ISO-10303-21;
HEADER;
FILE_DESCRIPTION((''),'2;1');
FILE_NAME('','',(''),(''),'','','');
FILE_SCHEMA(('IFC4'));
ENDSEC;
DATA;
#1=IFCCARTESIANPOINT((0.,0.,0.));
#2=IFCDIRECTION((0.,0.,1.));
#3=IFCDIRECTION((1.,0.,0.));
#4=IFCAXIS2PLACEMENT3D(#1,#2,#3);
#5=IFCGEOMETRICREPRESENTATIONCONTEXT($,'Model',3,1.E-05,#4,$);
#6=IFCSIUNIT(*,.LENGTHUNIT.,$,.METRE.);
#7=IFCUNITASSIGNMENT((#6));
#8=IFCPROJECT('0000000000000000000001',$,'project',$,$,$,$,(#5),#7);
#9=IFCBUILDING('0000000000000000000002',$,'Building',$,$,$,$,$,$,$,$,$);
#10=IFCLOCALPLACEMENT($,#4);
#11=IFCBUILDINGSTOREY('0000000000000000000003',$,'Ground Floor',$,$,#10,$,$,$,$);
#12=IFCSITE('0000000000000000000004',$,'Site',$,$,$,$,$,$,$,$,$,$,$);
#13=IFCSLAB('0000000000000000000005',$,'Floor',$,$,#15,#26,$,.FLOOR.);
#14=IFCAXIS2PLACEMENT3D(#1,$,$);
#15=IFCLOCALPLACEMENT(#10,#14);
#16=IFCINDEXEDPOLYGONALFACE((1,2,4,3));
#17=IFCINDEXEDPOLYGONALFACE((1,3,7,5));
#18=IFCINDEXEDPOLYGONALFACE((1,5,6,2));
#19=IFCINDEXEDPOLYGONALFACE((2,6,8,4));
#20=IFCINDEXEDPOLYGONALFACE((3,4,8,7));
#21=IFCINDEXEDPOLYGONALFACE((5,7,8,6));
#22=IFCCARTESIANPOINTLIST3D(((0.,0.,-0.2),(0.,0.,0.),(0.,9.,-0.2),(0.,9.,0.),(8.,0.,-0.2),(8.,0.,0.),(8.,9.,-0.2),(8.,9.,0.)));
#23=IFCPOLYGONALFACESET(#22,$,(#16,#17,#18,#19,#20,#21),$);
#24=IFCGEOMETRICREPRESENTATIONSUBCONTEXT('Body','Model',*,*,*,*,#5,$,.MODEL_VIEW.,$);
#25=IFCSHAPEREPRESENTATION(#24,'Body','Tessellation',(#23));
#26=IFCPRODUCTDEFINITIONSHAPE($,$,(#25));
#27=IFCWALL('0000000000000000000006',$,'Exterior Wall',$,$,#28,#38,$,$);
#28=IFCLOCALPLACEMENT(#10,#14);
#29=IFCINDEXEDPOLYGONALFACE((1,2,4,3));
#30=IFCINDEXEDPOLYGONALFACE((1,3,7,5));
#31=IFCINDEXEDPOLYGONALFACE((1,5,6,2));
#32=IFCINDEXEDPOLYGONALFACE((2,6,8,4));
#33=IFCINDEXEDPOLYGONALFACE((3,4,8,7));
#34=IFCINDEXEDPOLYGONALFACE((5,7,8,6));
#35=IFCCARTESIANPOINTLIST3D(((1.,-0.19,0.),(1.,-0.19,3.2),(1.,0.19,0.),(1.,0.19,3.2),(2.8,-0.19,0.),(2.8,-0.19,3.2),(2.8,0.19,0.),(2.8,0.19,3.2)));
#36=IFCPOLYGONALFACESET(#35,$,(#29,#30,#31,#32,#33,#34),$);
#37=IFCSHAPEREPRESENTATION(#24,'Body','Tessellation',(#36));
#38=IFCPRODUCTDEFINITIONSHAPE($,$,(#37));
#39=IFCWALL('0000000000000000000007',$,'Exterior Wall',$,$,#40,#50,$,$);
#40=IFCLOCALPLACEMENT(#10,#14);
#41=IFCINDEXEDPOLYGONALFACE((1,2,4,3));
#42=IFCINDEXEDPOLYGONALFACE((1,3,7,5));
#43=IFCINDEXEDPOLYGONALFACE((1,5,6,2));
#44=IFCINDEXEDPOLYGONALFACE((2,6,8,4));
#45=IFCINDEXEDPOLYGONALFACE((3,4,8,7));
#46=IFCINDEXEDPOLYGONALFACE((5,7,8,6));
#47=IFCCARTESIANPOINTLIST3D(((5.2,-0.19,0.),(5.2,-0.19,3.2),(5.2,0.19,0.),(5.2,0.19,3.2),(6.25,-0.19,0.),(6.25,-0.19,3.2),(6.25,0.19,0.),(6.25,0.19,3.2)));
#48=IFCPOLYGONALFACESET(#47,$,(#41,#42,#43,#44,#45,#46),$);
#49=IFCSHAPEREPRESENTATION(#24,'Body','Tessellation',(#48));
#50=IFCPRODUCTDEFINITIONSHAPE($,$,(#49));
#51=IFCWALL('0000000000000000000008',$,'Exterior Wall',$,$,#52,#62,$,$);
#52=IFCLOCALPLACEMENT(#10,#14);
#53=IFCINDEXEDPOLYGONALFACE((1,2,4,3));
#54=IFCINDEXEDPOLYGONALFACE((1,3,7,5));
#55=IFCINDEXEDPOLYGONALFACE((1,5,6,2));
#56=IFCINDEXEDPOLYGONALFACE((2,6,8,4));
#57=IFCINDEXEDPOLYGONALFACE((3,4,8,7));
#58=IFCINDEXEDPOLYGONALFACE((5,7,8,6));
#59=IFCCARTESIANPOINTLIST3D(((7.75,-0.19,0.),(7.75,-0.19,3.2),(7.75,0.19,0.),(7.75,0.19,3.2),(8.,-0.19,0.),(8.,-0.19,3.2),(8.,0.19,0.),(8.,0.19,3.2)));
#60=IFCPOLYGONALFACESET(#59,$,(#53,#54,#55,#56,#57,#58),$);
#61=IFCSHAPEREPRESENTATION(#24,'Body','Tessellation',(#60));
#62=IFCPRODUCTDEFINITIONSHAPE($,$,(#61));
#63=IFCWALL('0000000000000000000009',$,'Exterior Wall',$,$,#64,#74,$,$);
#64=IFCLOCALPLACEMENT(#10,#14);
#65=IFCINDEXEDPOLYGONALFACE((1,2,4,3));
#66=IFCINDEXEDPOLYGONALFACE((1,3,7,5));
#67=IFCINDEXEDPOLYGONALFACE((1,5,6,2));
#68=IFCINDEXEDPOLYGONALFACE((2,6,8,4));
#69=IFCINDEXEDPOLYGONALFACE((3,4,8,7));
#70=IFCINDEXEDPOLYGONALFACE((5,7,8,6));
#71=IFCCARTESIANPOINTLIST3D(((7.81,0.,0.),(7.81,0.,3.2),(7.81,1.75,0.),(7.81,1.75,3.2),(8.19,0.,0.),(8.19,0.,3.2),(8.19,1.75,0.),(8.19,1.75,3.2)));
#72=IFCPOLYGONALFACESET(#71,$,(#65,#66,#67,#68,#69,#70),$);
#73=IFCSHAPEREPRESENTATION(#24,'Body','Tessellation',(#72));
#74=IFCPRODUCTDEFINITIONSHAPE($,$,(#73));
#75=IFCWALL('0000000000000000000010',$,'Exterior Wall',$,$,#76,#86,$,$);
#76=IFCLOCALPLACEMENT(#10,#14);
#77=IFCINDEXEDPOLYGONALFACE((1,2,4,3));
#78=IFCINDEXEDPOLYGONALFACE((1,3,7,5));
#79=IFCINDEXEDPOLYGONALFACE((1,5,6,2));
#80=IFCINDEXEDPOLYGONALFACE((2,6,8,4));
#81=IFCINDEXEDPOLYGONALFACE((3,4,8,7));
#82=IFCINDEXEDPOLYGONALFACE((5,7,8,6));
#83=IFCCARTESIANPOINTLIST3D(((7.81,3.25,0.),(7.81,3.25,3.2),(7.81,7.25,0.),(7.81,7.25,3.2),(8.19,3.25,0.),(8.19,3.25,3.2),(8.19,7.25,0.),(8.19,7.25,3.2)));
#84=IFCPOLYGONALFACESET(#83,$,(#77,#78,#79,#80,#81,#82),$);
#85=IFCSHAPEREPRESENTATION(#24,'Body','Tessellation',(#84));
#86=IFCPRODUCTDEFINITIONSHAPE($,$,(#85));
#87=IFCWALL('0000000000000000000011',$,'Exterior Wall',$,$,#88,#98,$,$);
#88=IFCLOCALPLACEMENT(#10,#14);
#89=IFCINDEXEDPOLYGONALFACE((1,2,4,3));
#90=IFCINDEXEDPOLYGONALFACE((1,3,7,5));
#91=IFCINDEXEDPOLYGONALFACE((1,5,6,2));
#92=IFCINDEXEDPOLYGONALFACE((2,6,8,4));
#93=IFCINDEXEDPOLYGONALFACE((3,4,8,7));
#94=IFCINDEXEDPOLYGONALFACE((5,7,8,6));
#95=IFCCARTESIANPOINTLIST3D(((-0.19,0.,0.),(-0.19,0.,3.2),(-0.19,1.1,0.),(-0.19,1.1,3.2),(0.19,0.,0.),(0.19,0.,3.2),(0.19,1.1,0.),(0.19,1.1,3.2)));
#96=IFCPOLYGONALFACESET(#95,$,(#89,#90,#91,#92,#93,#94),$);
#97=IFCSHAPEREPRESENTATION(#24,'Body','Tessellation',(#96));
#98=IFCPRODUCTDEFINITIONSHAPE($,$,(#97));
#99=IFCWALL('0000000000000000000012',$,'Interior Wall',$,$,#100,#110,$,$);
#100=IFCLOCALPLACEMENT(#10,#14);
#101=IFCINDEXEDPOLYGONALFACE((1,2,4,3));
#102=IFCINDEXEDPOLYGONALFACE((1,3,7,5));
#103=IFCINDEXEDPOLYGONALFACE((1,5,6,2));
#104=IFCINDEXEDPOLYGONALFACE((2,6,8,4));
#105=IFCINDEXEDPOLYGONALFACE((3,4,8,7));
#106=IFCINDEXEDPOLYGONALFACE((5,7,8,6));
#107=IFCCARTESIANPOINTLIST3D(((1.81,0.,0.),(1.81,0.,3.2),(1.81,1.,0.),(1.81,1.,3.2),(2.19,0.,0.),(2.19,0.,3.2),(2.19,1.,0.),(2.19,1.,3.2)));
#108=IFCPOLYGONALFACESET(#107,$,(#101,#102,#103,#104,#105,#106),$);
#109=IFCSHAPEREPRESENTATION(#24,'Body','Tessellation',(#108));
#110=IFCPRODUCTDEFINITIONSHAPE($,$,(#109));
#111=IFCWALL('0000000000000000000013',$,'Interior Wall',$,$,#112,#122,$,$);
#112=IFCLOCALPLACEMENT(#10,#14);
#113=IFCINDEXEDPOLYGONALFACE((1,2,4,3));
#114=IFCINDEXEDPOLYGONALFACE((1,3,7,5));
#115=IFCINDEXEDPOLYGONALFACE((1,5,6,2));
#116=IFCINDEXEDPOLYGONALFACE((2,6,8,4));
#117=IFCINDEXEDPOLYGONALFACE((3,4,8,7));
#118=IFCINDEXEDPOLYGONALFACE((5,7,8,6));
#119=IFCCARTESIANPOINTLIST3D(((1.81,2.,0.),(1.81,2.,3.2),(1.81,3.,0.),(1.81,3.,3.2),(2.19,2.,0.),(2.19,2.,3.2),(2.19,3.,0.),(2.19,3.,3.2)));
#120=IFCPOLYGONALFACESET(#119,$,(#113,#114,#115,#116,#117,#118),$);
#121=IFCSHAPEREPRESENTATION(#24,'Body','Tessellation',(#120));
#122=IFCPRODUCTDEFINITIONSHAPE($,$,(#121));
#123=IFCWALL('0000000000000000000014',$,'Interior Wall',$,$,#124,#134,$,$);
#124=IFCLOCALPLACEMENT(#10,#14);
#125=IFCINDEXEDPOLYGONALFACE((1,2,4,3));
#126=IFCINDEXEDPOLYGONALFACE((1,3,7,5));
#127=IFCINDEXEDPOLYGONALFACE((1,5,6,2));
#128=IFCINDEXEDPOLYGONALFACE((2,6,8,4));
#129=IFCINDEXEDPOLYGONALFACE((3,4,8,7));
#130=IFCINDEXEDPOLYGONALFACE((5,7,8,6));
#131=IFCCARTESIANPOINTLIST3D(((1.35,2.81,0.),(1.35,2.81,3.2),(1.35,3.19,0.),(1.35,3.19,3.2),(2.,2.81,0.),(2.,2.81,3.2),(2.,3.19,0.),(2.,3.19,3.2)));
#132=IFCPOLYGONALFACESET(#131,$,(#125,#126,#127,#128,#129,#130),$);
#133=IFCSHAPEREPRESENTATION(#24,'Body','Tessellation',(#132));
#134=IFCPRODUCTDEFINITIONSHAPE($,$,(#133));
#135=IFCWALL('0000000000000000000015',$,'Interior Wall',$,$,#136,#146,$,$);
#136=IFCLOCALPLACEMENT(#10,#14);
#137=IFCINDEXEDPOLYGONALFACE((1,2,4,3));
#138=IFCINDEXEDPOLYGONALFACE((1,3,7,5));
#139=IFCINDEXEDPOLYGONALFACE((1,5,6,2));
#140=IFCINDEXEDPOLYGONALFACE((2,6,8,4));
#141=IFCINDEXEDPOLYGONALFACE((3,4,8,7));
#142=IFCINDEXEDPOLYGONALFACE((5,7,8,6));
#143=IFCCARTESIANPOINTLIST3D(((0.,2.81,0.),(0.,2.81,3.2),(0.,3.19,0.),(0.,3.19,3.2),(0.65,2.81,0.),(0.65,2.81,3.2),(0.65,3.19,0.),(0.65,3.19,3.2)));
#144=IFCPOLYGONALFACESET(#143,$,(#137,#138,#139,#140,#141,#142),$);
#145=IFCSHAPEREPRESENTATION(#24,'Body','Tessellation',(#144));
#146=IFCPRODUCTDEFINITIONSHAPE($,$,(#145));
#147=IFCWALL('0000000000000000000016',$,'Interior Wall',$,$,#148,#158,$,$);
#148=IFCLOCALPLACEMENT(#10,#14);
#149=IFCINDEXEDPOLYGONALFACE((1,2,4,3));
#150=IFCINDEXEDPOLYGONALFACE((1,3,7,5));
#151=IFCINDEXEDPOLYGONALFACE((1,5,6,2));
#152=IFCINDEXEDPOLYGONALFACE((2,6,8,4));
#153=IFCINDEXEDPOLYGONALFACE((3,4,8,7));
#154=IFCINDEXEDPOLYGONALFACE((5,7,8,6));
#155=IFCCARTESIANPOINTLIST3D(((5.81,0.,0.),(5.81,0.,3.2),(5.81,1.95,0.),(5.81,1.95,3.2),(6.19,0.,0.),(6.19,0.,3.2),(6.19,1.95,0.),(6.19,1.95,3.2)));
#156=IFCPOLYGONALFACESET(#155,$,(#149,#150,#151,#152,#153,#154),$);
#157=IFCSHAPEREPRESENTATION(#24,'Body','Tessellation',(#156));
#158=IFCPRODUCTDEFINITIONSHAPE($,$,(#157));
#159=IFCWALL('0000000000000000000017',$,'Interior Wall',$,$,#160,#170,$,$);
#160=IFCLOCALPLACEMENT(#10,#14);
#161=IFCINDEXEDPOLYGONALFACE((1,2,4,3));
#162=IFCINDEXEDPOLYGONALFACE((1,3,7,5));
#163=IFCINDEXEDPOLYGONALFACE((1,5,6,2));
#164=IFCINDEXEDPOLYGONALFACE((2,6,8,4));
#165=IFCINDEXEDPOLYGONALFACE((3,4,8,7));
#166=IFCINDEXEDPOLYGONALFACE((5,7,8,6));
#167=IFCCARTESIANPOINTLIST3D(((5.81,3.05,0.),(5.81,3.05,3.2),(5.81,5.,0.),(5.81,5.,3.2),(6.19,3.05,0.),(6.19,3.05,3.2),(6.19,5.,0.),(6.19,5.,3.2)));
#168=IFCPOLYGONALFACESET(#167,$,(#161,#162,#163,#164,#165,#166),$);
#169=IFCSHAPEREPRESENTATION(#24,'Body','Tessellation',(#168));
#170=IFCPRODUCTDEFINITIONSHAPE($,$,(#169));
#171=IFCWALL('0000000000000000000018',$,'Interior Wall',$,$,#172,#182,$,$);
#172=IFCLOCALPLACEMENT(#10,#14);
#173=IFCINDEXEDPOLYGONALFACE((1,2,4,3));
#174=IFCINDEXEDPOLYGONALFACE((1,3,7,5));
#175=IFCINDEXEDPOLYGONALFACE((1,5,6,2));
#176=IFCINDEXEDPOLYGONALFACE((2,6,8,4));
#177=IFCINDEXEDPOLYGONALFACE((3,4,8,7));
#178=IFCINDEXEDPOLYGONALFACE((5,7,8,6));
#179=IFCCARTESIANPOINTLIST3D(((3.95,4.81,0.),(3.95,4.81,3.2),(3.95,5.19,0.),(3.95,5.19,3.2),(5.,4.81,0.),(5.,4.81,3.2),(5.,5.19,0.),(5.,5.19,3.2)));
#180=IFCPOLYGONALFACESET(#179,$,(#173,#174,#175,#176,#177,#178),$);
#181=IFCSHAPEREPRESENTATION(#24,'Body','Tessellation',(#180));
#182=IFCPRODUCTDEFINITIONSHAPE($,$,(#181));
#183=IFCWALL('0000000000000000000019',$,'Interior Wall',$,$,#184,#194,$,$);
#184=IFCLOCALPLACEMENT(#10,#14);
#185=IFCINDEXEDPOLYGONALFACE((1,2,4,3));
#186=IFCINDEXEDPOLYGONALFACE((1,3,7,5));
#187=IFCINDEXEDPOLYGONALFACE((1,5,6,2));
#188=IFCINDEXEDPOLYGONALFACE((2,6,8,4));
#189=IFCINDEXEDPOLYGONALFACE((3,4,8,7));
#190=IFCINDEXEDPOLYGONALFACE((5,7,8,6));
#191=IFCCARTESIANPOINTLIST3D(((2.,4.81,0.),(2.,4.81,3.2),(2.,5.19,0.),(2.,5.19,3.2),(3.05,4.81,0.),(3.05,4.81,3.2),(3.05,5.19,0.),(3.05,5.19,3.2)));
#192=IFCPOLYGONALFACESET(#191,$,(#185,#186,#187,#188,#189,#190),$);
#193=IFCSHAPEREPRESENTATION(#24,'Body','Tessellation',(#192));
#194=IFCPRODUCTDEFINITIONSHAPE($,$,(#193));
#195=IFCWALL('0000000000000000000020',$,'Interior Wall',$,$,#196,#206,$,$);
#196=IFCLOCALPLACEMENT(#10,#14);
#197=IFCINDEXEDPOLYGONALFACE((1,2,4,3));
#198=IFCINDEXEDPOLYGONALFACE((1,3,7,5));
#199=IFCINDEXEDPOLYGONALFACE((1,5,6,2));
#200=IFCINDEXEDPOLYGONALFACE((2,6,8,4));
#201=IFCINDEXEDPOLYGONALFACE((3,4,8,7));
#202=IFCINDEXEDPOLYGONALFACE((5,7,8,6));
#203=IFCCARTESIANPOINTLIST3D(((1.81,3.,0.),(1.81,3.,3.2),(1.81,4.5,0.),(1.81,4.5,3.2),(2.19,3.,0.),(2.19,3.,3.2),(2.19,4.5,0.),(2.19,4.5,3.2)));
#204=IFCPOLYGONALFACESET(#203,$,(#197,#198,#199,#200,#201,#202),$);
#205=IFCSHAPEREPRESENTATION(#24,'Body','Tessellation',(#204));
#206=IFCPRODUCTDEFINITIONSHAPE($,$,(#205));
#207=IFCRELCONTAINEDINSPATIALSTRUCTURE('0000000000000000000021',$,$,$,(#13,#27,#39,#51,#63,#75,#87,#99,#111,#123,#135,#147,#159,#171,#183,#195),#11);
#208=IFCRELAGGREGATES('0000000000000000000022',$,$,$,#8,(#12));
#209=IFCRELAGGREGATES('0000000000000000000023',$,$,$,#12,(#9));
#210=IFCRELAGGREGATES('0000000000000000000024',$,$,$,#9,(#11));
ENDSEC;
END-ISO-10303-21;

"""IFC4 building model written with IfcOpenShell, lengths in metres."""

from ifc_helpers import new_model, si_unit, frame, origin_with_axes, place, context, subcontext, project, spatial, indexed_curve, outline, extrude, element, save


model = new_model("IFC4")

# Units and contexts
model_context = context("Model", 3, precision=1e-05, world=origin_with_axes())
body_context = subcontext(model_context, "Body", "Model", "MODEL_VIEW")
ifc_project = project(units=[si_unit("LENGTHUNIT", "METRE")], contexts=[model_context])

# Site, building, storey
site = spatial("IfcSite", under=ifc_project, Name="Site")
building = spatial("IfcBuilding", under=site, Name="Building")
storey_placement = place(None, origin_with_axes())
storey = spatial("IfcBuildingStorey", under=building, at=storey_placement, Name="Ground Floor")

# Slab
slab_placement = place(storey_placement, frame((0.0, 0.0, -0.2), z_axis=(0.0, 0.0, 1.0), x_axis=(1.0, 0.0, 0.0)))
element("IfcSlab", 1, at=slab_placement, inside=storey, Name="Floor", PredefinedType="FLOOR", context=body_context, shape_type="SweptSolid", body=[
    extrude(outline(indexed_curve([(0.0, 0.0), (8.0, 0.0), (8.0, 9.0), (0.0, 9.0)])), None, (0.0, 0.0, 1.0), 0.2),
])

# Walls
wall_1_placement = place(storey_placement, frame((1.0, 0.0, 0.0), z_axis=(0.0, 0.0, 1.0), x_axis=(1.0, 0.0, 0.0)))
element("IfcWall", 2, at=wall_1_placement, inside=storey, Name="Exterior Wall", context=body_context, shape_type="SweptSolid", body=[
    extrude(outline(indexed_curve([(0.0, 0.0), (0.0, 0.38), (1.8, 0.38), (1.8, 0.0), (0.0, 0.0)], self_intersect=False)), frame((0.0, -0.19, 0.0), z_axis=(0.0, 0.0, 1.0), x_axis=(1.0, 0.0, 0.0)), (0.0, 0.0, 1.0), 3.2),
])
wall_2_placement = place(storey_placement, frame((5.2, 0.0, 0.0), z_axis=(0.0, 0.0, 1.0), x_axis=(1.0, 0.0, 0.0)))
element("IfcWall", 3, at=wall_2_placement, inside=storey, Name="Exterior Wall", context=body_context, shape_type="SweptSolid", body=[
    extrude(outline(indexed_curve([(0.0, 0.0), (0.0, 0.38), (1.05, 0.38), (1.05, 0.0), (0.0, 0.0)], self_intersect=False)), frame((0.0, -0.19, 0.0), z_axis=(0.0, 0.0, 1.0), x_axis=(1.0, 0.0, 0.0)), (0.0, 0.0, 1.0), 3.2),
])
wall_3_placement = place(storey_placement, frame((7.75, 0.0, 0.0), z_axis=(0.0, 0.0, 1.0), x_axis=(1.0, 0.0, 0.0)))
element("IfcWall", 4, at=wall_3_placement, inside=storey, Name="Exterior Wall", context=body_context, shape_type="SweptSolid", body=[
    extrude(outline(indexed_curve([(0.0, 0.0), (0.0, 0.38), (0.25, 0.38), (0.25, 0.0), (0.0, 0.0)], self_intersect=False)), frame((0.0, -0.19, 0.0), z_axis=(0.0, 0.0, 1.0), x_axis=(1.0, 0.0, 0.0)), (0.0, 0.0, 1.0), 3.2),
])
wall_4_placement = place(storey_placement, frame((8.0, 0.0, 0.0), z_axis=(0.0, 0.0, 1.0), x_axis=(0.0, 1.0, 0.0)))
element("IfcWall", 5, at=wall_4_placement, inside=storey, Name="Exterior Wall", context=body_context, shape_type="SweptSolid", body=[
    extrude(outline(indexed_curve([(0.0, 0.0), (0.0, 0.38), (1.75, 0.38), (1.75, 0.0), (0.0, 0.0)], self_intersect=False)), frame((0.0, -0.19, 0.0), z_axis=(0.0, 0.0, 1.0), x_axis=(1.0, 0.0, 0.0)), (0.0, 0.0, 1.0), 3.2),
])
wall_5_placement = place(storey_placement, frame((8.0, 3.25, 0.0), z_axis=(0.0, 0.0, 1.0), x_axis=(0.0, 1.0, 0.0)))
element("IfcWall", 6, at=wall_5_placement, inside=storey, Name="Exterior Wall", context=body_context, shape_type="SweptSolid", body=[
    extrude(outline(indexed_curve([(0.0, 0.0), (0.0, 0.38), (4.0, 0.38), (4.0, 0.0), (0.0, 0.0)], self_intersect=False)), frame((0.0, -0.19, 0.0), z_axis=(0.0, 0.0, 1.0), x_axis=(1.0, 0.0, 0.0)), (0.0, 0.0, 1.0), 3.2),
])
wall_6_placement = place(storey_placement, frame((0.0, 1.1, 0.0), z_axis=(0.0, 0.0, 1.0), x_axis=(0.0, -1.0, 0.0)))
element("IfcWall", 7, at=wall_6_placement, inside=storey, Name="Exterior Wall", context=body_context, shape_type="SweptSolid", body=[
    extrude(outline(indexed_curve([(0.0, 0.0), (0.0, 0.38), (1.1, 0.38), (1.1, 0.0), (0.0, 0.0)], self_intersect=False)), frame((0.0, -0.19, 0.0), z_axis=(0.0, 0.0, 1.0), x_axis=(1.0, 0.0, 0.0)), (0.0, 0.0, 1.0), 3.2),
])
for number, where, z_axis, x_axis, name in (
    (8, (2.0, 0.0, 0.0), (0.0, 0.0, 1.0), (0.0, 1.0, 0.0), "Interior Wall"),
    (9, (2.0, 2.0, 0.0), (0.0, 0.0, 1.0), (0.0, 1.0, 0.0), "Interior Wall"),
):
    element("IfcWall", number, at=place(storey_placement, frame(where, z_axis=z_axis, x_axis=x_axis)), inside=storey, Name=name, context=body_context, shape_type="SweptSolid", body=[
        extrude(outline(indexed_curve([(0.0, 0.0), (0.0, 0.38), (1.0, 0.38), (1.0, 0.0), (0.0, 0.0)], self_intersect=False)), frame((0.0, -0.19, 0.0), z_axis=(0.0, 0.0, 1.0), x_axis=(1.0, 0.0, 0.0)), (0.0, 0.0, 1.0), 3.2),
    ])
for number, where, z_axis, x_axis, name in (
    (10, (2.0, 3.0, 0.0), (0.0, 0.0, 1.0), (-1.0, 0.0, 0.0), "Interior Wall"),
    (11, (0.65, 3.0, 0.0), (0.0, 0.0, 1.0), (-1.0, 0.0, 0.0), "Interior Wall"),
):
    element("IfcWall", number, at=place(storey_placement, frame(where, z_axis=z_axis, x_axis=x_axis)), inside=storey, Name=name, context=body_context, shape_type="SweptSolid", body=[
        extrude(outline(indexed_curve([(0.0, 0.0), (0.0, 0.38), (0.65, 0.38), (0.65, 0.0), (0.0, 0.0)], self_intersect=False)), frame((0.0, -0.19, 0.0), z_axis=(0.0, 0.0, 1.0), x_axis=(1.0, 0.0, 0.0)), (0.0, 0.0, 1.0), 3.2),
    ])
wall_7_placement = place(storey_placement, frame((6.0, 0.0, 0.0), z_axis=(0.0, 0.0, 1.0), x_axis=(0.0, 1.0, 0.0)))
element("IfcWall", 12, at=wall_7_placement, inside=storey, Name="Interior Wall", context=body_context, shape_type="SweptSolid", body=[
    extrude(outline(indexed_curve([(0.0, 0.0), (0.0, 0.38), (1.95, 0.38), (1.95, 0.0), (0.0, 0.0)], self_intersect=False)), frame((0.0, -0.19, 0.0), z_axis=(0.0, 0.0, 1.0), x_axis=(1.0, 0.0, 0.0)), (0.0, 0.0, 1.0), 3.2),
])
wall_8_placement = place(storey_placement, frame((6.0, 3.05, 0.0), z_axis=(0.0, 0.0, 1.0), x_axis=(0.0, 1.0, 0.0)))
element("IfcWall", 13, at=wall_8_placement, inside=storey, Name="Interior Wall", context=body_context, shape_type="SweptSolid", body=[
    extrude(outline(indexed_curve([(0.0, 0.0), (0.0, 0.38), (1.95, 0.38), (1.95, 0.0), (0.0, 0.0)], self_intersect=False)), frame((0.0, -0.19, 0.0), z_axis=(0.0, 0.0, 1.0), x_axis=(1.0, 0.0, 0.0)), (0.0, 0.0, 1.0), 3.2),
])
for number, where, z_axis, x_axis, name in (
    (14, (5.0, 5.0, 0.0), (0.0, 0.0, 1.0), (-1.0, 0.0, 0.0), "Interior Wall"),
    (15, (3.05, 5.0, 0.0), (0.0, 0.0, 1.0), (-1.0, 0.0, 0.0), "Interior Wall"),
):
    element("IfcWall", number, at=place(storey_placement, frame(where, z_axis=z_axis, x_axis=x_axis)), inside=storey, Name=name, context=body_context, shape_type="SweptSolid", body=[
        extrude(outline(indexed_curve([(0.0, 0.0), (0.0, 0.38), (1.05, 0.38), (1.05, 0.0), (0.0, 0.0)], self_intersect=False)), frame((0.0, -0.19, 0.0), z_axis=(0.0, 0.0, 1.0), x_axis=(1.0, 0.0, 0.0)), (0.0, 0.0, 1.0), 3.2),
    ])
wall_9_placement = place(storey_placement, frame((2.0, 4.5, 0.0), z_axis=(0.0, 0.0, 1.0), x_axis=(0.0, -1.0, 0.0)))
element("IfcWall", 16, at=wall_9_placement, inside=storey, Name="Interior Wall", context=body_context, shape_type="SweptSolid", body=[
    extrude(outline(indexed_curve([(0.0, 0.0), (0.0, 0.38), (1.5, 0.38), (1.5, 0.0), (0.0, 0.0)], self_intersect=False)), frame((0.0, -0.19, 0.0), z_axis=(0.0, 0.0, 1.0), x_axis=(1.0, 0.0, 0.0)), (0.0, 0.0, 1.0), 3.2),
])

save(model, "model.ifc")
